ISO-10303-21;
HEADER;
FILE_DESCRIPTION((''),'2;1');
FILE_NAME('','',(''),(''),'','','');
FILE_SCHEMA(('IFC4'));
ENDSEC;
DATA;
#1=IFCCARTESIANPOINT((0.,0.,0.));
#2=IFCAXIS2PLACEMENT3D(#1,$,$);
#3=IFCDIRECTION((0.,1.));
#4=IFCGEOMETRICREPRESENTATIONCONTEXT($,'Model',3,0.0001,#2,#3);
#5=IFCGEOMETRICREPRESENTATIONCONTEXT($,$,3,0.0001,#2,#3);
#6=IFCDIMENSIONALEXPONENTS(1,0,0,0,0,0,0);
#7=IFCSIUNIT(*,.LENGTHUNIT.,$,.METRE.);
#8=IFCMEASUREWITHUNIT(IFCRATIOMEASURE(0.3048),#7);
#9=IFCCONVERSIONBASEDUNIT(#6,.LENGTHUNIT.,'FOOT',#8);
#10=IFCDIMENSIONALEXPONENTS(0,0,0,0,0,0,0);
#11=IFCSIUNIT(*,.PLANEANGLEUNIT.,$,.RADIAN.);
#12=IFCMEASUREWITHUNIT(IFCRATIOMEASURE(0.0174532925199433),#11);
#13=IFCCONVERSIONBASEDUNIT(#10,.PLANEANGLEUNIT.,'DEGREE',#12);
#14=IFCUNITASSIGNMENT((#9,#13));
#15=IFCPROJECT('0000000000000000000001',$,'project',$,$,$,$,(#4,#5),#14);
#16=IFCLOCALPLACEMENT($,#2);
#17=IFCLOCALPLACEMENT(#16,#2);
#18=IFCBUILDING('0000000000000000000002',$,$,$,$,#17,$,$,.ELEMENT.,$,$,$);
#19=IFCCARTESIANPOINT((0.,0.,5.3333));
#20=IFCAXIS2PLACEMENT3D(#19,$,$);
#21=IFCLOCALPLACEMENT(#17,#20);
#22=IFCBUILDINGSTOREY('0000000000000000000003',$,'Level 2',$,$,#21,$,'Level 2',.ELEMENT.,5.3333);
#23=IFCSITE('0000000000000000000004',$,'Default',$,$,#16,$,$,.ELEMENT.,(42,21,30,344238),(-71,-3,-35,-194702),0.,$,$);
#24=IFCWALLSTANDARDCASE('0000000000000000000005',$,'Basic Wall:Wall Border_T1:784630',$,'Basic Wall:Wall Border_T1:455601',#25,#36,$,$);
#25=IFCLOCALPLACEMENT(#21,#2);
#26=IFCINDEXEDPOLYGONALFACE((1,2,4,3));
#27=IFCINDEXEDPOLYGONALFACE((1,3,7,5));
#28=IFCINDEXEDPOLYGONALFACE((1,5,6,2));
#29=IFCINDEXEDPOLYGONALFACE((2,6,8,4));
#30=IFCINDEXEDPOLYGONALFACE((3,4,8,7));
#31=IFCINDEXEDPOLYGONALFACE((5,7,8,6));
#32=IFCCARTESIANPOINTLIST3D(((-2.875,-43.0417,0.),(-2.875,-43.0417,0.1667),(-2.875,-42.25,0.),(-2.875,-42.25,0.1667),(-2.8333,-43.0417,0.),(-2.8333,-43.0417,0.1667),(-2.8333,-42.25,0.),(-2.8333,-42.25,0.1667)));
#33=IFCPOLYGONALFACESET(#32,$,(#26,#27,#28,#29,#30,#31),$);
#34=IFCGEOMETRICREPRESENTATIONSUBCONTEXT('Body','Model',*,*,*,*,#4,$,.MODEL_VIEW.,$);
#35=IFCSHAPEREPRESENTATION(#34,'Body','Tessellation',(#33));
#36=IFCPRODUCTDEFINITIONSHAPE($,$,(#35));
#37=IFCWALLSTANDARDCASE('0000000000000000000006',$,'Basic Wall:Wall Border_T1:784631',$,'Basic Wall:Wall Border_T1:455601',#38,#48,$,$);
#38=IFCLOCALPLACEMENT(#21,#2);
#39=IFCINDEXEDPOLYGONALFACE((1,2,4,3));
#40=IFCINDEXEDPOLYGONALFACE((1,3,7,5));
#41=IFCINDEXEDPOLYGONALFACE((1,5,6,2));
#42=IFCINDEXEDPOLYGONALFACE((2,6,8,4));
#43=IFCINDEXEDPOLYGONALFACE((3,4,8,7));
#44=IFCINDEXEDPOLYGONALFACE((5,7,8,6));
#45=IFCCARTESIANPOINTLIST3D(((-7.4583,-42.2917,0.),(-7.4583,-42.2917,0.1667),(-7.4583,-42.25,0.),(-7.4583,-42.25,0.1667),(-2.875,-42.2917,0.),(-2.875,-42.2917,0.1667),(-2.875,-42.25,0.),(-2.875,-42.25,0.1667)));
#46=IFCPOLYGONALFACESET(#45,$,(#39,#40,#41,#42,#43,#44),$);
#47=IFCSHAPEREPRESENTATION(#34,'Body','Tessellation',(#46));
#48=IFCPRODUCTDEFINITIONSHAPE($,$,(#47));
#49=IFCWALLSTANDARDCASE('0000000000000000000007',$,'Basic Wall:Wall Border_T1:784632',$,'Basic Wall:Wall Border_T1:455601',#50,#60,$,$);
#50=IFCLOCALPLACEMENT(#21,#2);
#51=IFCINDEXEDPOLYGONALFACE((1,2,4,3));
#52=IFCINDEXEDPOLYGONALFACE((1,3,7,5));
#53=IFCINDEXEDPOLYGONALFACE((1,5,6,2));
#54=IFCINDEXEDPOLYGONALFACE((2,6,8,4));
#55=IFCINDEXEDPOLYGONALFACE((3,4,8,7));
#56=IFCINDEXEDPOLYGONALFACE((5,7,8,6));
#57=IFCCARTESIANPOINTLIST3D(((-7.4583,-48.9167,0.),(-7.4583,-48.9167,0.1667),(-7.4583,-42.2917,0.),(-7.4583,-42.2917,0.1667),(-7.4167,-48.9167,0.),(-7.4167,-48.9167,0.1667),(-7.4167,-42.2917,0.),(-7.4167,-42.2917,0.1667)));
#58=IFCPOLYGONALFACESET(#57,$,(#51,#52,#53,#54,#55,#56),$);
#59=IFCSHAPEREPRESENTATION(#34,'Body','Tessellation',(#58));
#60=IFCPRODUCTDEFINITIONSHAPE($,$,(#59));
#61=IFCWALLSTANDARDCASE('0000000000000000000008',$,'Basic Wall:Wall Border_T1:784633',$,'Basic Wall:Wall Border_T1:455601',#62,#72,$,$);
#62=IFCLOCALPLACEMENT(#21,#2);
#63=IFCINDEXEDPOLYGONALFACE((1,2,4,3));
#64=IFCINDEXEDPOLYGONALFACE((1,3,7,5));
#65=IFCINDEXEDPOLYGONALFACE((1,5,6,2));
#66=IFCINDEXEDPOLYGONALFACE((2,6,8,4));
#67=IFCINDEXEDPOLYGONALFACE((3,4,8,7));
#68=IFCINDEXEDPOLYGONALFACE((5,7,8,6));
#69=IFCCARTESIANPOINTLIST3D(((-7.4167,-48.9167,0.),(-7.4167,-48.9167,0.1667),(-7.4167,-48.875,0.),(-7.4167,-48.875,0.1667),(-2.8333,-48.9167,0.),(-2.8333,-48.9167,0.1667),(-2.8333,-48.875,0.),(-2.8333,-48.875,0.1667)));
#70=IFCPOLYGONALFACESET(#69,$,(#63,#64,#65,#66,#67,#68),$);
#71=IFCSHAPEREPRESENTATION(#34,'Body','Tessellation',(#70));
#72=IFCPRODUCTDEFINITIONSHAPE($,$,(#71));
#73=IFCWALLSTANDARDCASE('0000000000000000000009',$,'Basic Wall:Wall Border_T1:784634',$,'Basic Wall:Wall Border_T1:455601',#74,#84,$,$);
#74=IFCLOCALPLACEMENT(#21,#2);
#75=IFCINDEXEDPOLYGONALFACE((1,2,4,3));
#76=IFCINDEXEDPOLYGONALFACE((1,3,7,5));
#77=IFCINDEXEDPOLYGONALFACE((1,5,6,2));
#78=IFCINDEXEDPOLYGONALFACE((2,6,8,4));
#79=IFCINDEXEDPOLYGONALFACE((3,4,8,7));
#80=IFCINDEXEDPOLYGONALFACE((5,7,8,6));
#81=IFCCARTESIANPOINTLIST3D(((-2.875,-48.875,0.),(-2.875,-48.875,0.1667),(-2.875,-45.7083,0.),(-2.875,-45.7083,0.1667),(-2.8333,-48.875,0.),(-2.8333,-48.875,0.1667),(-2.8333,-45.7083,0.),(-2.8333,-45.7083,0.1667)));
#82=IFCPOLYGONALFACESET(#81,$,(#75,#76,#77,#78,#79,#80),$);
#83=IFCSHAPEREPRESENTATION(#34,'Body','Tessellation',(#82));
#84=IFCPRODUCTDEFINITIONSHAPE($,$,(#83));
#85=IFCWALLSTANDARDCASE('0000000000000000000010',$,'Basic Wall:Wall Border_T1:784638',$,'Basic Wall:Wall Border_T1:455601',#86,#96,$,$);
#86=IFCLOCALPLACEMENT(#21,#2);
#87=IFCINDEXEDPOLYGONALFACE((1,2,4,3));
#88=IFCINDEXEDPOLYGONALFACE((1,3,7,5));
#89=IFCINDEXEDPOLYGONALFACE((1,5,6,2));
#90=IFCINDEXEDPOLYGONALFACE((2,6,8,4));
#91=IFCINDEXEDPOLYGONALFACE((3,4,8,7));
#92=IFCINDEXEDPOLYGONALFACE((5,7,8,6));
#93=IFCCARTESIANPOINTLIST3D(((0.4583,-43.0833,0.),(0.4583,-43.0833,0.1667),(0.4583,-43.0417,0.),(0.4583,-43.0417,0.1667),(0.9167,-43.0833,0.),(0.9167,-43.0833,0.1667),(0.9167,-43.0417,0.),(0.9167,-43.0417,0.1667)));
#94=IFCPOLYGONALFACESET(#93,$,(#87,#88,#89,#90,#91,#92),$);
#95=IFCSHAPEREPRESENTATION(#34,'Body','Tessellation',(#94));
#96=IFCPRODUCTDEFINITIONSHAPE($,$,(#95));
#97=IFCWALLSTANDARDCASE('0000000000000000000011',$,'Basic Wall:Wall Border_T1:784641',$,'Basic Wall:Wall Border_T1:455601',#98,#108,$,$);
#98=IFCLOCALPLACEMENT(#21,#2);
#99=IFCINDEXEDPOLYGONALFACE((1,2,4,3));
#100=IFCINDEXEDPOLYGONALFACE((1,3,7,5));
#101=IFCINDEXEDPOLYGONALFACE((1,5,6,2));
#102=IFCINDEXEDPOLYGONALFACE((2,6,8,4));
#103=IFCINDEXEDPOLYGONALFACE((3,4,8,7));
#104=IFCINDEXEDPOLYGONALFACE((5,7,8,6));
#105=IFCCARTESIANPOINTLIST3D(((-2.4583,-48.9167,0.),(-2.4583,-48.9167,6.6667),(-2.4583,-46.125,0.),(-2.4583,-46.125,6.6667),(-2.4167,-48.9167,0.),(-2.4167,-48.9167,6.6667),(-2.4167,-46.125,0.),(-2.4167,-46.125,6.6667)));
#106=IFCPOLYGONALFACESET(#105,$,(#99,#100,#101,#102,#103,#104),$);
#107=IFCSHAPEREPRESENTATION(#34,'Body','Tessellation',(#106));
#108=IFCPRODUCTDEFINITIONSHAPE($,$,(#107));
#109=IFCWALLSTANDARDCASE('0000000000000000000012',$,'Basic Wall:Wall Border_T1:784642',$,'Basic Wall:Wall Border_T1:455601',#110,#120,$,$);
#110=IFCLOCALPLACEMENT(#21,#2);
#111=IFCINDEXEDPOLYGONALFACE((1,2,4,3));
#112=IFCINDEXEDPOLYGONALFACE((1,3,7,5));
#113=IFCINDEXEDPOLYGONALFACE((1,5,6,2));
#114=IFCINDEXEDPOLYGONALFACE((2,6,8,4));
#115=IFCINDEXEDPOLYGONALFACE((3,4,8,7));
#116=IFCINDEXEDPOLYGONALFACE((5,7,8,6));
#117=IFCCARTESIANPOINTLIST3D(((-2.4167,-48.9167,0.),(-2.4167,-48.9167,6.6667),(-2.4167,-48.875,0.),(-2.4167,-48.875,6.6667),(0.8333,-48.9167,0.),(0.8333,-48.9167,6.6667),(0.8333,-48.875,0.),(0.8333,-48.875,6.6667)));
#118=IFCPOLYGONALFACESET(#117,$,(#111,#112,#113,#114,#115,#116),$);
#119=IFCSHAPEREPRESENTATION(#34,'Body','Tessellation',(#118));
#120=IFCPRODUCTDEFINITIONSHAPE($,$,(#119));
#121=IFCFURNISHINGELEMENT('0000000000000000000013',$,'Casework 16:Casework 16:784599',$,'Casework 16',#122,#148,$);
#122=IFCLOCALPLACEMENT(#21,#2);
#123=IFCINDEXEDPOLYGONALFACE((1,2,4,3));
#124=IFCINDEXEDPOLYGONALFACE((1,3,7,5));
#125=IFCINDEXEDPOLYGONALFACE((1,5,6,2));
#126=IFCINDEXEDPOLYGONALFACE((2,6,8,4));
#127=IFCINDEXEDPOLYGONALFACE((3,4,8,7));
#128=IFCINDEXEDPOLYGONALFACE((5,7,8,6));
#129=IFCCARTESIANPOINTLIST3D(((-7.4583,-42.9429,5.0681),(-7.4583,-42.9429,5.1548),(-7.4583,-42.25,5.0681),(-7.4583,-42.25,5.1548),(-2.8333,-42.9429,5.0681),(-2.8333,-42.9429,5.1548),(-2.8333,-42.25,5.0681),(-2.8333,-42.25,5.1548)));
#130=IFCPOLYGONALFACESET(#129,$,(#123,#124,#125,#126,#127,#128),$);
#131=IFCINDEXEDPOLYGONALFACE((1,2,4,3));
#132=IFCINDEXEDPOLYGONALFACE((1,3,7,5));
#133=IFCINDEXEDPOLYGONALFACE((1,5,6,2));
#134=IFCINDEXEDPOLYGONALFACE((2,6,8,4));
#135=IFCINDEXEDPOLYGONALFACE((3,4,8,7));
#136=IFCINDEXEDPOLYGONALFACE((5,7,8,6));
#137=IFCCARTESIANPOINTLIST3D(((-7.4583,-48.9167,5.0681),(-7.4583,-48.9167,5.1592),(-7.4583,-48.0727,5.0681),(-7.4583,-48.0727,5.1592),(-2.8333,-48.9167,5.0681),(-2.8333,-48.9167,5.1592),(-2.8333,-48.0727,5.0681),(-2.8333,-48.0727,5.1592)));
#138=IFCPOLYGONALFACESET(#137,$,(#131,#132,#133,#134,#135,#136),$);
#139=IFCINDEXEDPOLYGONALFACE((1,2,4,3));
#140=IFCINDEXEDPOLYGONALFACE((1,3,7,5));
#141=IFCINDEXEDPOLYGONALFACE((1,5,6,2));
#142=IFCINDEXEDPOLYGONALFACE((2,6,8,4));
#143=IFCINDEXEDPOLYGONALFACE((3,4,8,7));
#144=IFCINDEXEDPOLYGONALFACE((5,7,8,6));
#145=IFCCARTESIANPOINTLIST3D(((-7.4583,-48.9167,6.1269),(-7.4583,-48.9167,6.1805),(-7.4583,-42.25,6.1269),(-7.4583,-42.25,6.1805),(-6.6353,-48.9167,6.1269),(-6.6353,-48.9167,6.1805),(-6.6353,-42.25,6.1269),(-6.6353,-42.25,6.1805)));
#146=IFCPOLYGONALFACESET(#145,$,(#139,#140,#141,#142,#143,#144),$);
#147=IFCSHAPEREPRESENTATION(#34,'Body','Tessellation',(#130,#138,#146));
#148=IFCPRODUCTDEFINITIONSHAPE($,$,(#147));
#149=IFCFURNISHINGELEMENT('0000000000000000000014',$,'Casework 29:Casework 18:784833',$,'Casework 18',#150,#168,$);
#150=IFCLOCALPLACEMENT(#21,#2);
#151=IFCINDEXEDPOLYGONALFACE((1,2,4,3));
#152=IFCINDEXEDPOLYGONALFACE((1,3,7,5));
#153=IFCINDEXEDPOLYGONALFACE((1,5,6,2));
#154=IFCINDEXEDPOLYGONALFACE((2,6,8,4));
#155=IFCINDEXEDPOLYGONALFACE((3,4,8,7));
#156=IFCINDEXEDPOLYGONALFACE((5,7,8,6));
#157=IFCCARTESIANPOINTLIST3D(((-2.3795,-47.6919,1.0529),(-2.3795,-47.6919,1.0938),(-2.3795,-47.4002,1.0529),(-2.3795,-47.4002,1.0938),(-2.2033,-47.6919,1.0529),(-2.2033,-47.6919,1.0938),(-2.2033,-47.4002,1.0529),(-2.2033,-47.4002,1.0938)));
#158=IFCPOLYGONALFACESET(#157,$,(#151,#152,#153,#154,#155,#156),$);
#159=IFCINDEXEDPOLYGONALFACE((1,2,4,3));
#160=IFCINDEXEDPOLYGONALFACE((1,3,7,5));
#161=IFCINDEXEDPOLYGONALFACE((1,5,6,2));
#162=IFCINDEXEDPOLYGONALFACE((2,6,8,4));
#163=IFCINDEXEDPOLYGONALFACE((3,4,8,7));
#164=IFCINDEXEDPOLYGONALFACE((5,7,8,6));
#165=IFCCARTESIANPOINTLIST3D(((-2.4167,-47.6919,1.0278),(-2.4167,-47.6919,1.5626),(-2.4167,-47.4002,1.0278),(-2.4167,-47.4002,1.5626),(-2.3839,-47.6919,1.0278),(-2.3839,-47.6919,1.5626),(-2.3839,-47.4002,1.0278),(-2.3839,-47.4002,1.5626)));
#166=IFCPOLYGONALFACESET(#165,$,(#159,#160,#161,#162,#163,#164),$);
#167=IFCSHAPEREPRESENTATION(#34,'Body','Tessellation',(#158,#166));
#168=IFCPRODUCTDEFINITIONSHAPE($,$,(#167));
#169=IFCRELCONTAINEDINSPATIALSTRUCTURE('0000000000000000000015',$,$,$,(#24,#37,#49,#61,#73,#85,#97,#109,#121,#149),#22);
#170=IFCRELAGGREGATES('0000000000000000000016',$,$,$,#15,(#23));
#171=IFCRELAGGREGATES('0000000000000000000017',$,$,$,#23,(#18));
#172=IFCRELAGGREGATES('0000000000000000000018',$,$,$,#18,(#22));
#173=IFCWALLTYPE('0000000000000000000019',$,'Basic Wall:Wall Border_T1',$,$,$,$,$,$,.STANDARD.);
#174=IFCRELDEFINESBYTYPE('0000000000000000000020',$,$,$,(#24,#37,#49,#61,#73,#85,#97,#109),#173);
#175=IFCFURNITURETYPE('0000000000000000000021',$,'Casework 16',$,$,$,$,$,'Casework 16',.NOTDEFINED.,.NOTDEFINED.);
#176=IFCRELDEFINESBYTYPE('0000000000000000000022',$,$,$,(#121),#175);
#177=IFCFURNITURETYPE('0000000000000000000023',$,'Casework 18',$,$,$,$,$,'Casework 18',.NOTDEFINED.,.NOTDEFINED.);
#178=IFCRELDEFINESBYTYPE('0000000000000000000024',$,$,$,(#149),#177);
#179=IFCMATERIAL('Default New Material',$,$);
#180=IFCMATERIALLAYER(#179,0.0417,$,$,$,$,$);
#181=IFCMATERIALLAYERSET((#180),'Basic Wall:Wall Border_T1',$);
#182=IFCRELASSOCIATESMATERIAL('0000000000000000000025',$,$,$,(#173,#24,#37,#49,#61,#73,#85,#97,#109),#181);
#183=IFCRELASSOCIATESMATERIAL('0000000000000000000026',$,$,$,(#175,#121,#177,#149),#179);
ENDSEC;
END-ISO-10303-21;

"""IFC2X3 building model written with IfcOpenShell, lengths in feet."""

from ifc_helpers import new_model, entity, si_unit, converted_unit, direction, frame, frame_2d, origin, place, context, subcontext, project, spatial, rectangle, extrude, source, transform, mapped, material, layer, layer_set, layer_usage, type_object, type_shapes, element, save


model = new_model("IFC2X3")

# Units and contexts
model_context = context("Model", 3, precision=0.0001, world=origin(), true_north=direction((0.0, 1.0)))
context_of_model = context(None, 3, precision=0.0001, world=origin(), true_north=direction((0.0, 1.0)))
body_context = subcontext(model_context, "Body", "Model", "MODEL_VIEW")
ifc_project = project(units=[converted_unit("LENGTHUNIT", "FOOT", entity("IfcRatioMeasure", 0.3048), si_unit("LENGTHUNIT", "METRE"), dimensions=[1, 0, 0, 0, 0, 0, 0]), converted_unit("PLANEANGLEUNIT", "DEGREE", entity("IfcRatioMeasure", 0.0174532925199433), si_unit("PLANEANGLEUNIT", "RADIAN"), dimensions=[0, 0, 0, 0, 0, 0, 0])], contexts=[model_context, context_of_model])

# Site, building, storey
site_placement = place(None, origin())
site = spatial("IfcSite", under=ifc_project, at=site_placement, Name="Default", CompositionType="ELEMENT", RefLatitude=(42, 21, 30, 344238), RefLongitude=(-71, -3, -35, -194702), RefElevation=0.0)
building_placement = place(site_placement, origin())
building = spatial("IfcBuilding", under=site, at=building_placement, CompositionType="ELEMENT")
storey_placement = place(building_placement, frame((0.0, 0.0, 5.3333)))
storey = spatial("IfcBuildingStorey", under=building, at=storey_placement, Name="Level 2", LongName="Level 2", CompositionType="ELEMENT", Elevation=5.3333)

# Shared definitions
ifc_material_1 = material(Name="Default New Material")

# Walls
ifc_layer_1 = layer(ifc_material_1, 0.0417)
ifc_layer_set_1 = layer_set([ifc_layer_1], Name="Basic Wall:Wall Border_T1")
wall_type_1 = type_object("IfcWallType", Name="Basic Wall:Wall Border_T1", PredefinedType="STANDARD", material=ifc_layer_set_1)
ifc_layer_usage_1 = layer_usage(ifc_layer_set_1, "AXIS2", "NEGATIVE", 0.0208)
wall_1_placement = place(storey_placement, frame((-2.8542, -43.0417, 0.0), z_axis=(0.0, 0.0, 1.0), x_axis=(0.0, 1.0, 0.0)))
element("IfcWallStandardCase", 1, at=wall_1_placement, inside=storey, type_object=wall_type_1, material=ifc_layer_usage_1, Name="Basic Wall:Wall Border_T1:784630", ObjectType="Basic Wall:Wall Border_T1:455601", context=body_context, shape_type="SweptSolid", body=[
    extrude(rectangle(XDim=0.7917, YDim=0.0417, at=frame_2d((0.3958, 0.0), x_axis=(-1.0, 0.0))), origin(), (0.0, 0.0, 1.0), 0.1667),
])
ifc_layer_usage_2 = layer_usage(ifc_layer_set_1, "AXIS2", "NEGATIVE", 0.0208)
wall_2_placement = place(storey_placement, frame((-2.875, -42.2708, 0.0), z_axis=(0.0, 0.0, 1.0), x_axis=(-1.0, 0.0, 0.0)))
element("IfcWallStandardCase", 2, at=wall_2_placement, inside=storey, type_object=wall_type_1, material=ifc_layer_usage_2, Name="Basic Wall:Wall Border_T1:784631", ObjectType="Basic Wall:Wall Border_T1:455601", context=body_context, shape_type="SweptSolid", body=[
    extrude(rectangle(XDim=4.5833, YDim=0.0417, at=frame_2d((2.2917, 0.0), x_axis=(-1.0, 0.0))), origin(), (0.0, 0.0, 1.0), 0.1667),
])
ifc_layer_usage_3 = layer_usage(ifc_layer_set_1, "AXIS2", "NEGATIVE", 0.0208)
wall_3_placement = place(storey_placement, frame((-7.4375, -42.2917, 0.0), z_axis=(0.0, 0.0, 1.0), x_axis=(0.0, -1.0, 0.0)))
element("IfcWallStandardCase", 3, at=wall_3_placement, inside=storey, type_object=wall_type_1, material=ifc_layer_usage_3, Name="Basic Wall:Wall Border_T1:784632", ObjectType="Basic Wall:Wall Border_T1:455601", context=body_context, shape_type="SweptSolid", body=[
    extrude(rectangle(XDim=6.625, YDim=0.0417, at=frame_2d((3.3125, 0.0), x_axis=(-1.0, 0.0))), origin(), (0.0, 0.0, 1.0), 0.1667),
])
ifc_layer_usage_4 = layer_usage(ifc_layer_set_1, "AXIS2", "NEGATIVE", 0.0208)
wall_4_placement = place(storey_placement, frame((-7.4167, -48.8958, 0.0)))
element("IfcWallStandardCase", 4, at=wall_4_placement, inside=storey, type_object=wall_type_1, material=ifc_layer_usage_4, Name="Basic Wall:Wall Border_T1:784633", ObjectType="Basic Wall:Wall Border_T1:455601", context=body_context, shape_type="SweptSolid", body=[
    extrude(rectangle(XDim=4.5833, YDim=0.0417, at=frame_2d((2.2917, 0.0), x_axis=(-1.0, 0.0))), origin(), (0.0, 0.0, 1.0), 0.1667),
])
ifc_layer_usage_5 = layer_usage(ifc_layer_set_1, "AXIS2", "NEGATIVE", 0.0208)
wall_5_placement = place(storey_placement, frame((-2.8542, -48.875, 0.0), z_axis=(0.0, 0.0, 1.0), x_axis=(0.0, 1.0, 0.0)))
element("IfcWallStandardCase", 5, at=wall_5_placement, inside=storey, type_object=wall_type_1, material=ifc_layer_usage_5, Name="Basic Wall:Wall Border_T1:784634", ObjectType="Basic Wall:Wall Border_T1:455601", context=body_context, shape_type="SweptSolid", body=[
    extrude(rectangle(XDim=3.1667, YDim=0.0417, at=frame_2d((1.5833, 0.0), x_axis=(-1.0, 0.0))), origin(), (0.0, 0.0, 1.0), 0.1667),
])
ifc_layer_usage_6 = layer_usage(ifc_layer_set_1, "AXIS2", "POSITIVE", -0.0208)
wall_6_placement = place(storey_placement, frame((0.4583, -43.0625, 0.0)))
element("IfcWallStandardCase", 6, at=wall_6_placement, inside=storey, type_object=wall_type_1, material=ifc_layer_usage_6, Name="Basic Wall:Wall Border_T1:784638", ObjectType="Basic Wall:Wall Border_T1:455601", context=body_context, shape_type="SweptSolid", body=[
    extrude(rectangle(XDim=0.4583, YDim=0.0417, at=frame_2d((0.2292, 0.0), x_axis=(-1.0, 0.0))), origin(), (0.0, 0.0, 1.0), 0.1667),
])
ifc_layer_usage_7 = layer_usage(ifc_layer_set_1, "AXIS2", "NEGATIVE", 0.0208)
wall_7_placement = place(storey_placement, frame((-2.4375, -46.125, 0.0), z_axis=(0.0, 0.0, 1.0), x_axis=(0.0, -1.0, 0.0)))
element("IfcWallStandardCase", 7, at=wall_7_placement, inside=storey, type_object=wall_type_1, material=ifc_layer_usage_7, Name="Basic Wall:Wall Border_T1:784641", ObjectType="Basic Wall:Wall Border_T1:455601", context=body_context, shape_type="SweptSolid", body=[
    extrude(rectangle(XDim=2.7917, YDim=0.0417, at=frame_2d((1.3958, 0.0), x_axis=(-1.0, 0.0))), origin(), (0.0, 0.0, 1.0), 6.6667),
])
ifc_layer_usage_8 = layer_usage(ifc_layer_set_1, "AXIS2", "NEGATIVE", 0.0208)
wall_8_placement = place(storey_placement, frame((-2.4167, -48.8958, 0.0)))
element("IfcWallStandardCase", 8, at=wall_8_placement, inside=storey, type_object=wall_type_1, material=ifc_layer_usage_8, Name="Basic Wall:Wall Border_T1:784642", ObjectType="Basic Wall:Wall Border_T1:455601", context=body_context, shape_type="SweptSolid", body=[
    extrude(rectangle(XDim=3.25, YDim=0.0417, at=frame_2d((1.625, 0.0), x_axis=(-1.0, 0.0))), origin(), (0.0, 0.0, 1.0), 6.6667),
])

# Furnishing elements
furniture_type_1 = type_object("IfcFurnitureType", Name="Casework 16", ElementType="Casework 16", AssemblyPlace="NOTDEFINED", material=ifc_material_1)
shared_shape_1 = source(origin(), body_context, "Body", "SweptSolid", [
    extrude(rectangle(XDim=0.6929, YDim=4.625, at=frame_2d((0.0, 0.0), x_axis=(1.0, 0.0))), frame((2.3125, 6.3202, 0.0), z_axis=(0.0, 0.0, 1.0), x_axis=(0.0, 1.0, 0.0)), (0.0, 0.0, 1.0), 0.0867),
    extrude(rectangle(XDim=0.844, YDim=4.625, at=frame_2d((0.0, 0.0), x_axis=(1.0, 0.0))), frame((2.3125, 0.422, 0.0), z_axis=(0.0, 0.0, 1.0), x_axis=(0.0, -1.0, 0.0)), (0.0, 0.0, 1.0), 0.091),
    extrude(rectangle(XDim=0.8231, YDim=6.6667, at=frame_2d((0.0, 0.0), x_axis=(1.0, 0.0))), frame((0.4115, 3.3333, 1.0588), z_axis=(0.0, 0.0, 1.0), x_axis=(-1.0, 0.0, 0.0)), (0.0, 0.0, 1.0), 0.0536),
])
type_shapes(furniture_type_1, [shared_shape_1])
furnishing_1_placement = place(storey_placement, frame((-7.4583, -48.9167, 5.0681)))
element("IfcFurnishingElement", 9, at=furnishing_1_placement, inside=storey, type_object=furniture_type_1, material=ifc_material_1, Name="Casework 16:Casework 16:784599", ObjectType="Casework 16", context=body_context, shape_type="MappedRepresentation", body=[
    mapped(shared_shape_1, transform((0.0, 0.0, 0.0), scale=1.0)),
])
furniture_type_2 = type_object("IfcFurnitureType", Name="Casework 18", ElementType="Casework 18", AssemblyPlace="NOTDEFINED", material=ifc_material_1)
shared_shape_2 = source(origin(), body_context, "Body", "SweptSolid", [
    extrude(rectangle(XDim=0.1762, YDim=0.2917, at=frame_2d((0.0, 0.0), x_axis=(1.0, 0.0))), frame((0.1253, 0.1458, 0.0251), z_axis=(0.0, 0.0, 1.0), x_axis=(-1.0, 0.0, 0.0)), (0.0, 0.0, 1.0), 0.0408),
    extrude(rectangle(XDim=0.0328, YDim=0.2917, at=frame_2d((0.0, 0.0), x_axis=(1.0, 0.0))), frame((0.0164, 0.1458, 0.0), z_axis=(0.0, 0.0, 1.0), x_axis=(-1.0, 0.0, 0.0)), (0.0, 0.0, 1.0), 0.5348),
])
type_shapes(furniture_type_2, [shared_shape_2])
furnishing_2_placement = place(storey_placement, frame((-2.4167, -47.6919, 1.0278)))
element("IfcFurnishingElement", 10, at=furnishing_2_placement, inside=storey, type_object=furniture_type_2, material=ifc_material_1, Name="Casework 29:Casework 18:784833", ObjectType="Casework 18", context=body_context, shape_type="MappedRepresentation", body=[
    mapped(shared_shape_2, transform((0.0, 0.0, 0.0), scale=1.0)),
])

save(model, "model.ifc")
